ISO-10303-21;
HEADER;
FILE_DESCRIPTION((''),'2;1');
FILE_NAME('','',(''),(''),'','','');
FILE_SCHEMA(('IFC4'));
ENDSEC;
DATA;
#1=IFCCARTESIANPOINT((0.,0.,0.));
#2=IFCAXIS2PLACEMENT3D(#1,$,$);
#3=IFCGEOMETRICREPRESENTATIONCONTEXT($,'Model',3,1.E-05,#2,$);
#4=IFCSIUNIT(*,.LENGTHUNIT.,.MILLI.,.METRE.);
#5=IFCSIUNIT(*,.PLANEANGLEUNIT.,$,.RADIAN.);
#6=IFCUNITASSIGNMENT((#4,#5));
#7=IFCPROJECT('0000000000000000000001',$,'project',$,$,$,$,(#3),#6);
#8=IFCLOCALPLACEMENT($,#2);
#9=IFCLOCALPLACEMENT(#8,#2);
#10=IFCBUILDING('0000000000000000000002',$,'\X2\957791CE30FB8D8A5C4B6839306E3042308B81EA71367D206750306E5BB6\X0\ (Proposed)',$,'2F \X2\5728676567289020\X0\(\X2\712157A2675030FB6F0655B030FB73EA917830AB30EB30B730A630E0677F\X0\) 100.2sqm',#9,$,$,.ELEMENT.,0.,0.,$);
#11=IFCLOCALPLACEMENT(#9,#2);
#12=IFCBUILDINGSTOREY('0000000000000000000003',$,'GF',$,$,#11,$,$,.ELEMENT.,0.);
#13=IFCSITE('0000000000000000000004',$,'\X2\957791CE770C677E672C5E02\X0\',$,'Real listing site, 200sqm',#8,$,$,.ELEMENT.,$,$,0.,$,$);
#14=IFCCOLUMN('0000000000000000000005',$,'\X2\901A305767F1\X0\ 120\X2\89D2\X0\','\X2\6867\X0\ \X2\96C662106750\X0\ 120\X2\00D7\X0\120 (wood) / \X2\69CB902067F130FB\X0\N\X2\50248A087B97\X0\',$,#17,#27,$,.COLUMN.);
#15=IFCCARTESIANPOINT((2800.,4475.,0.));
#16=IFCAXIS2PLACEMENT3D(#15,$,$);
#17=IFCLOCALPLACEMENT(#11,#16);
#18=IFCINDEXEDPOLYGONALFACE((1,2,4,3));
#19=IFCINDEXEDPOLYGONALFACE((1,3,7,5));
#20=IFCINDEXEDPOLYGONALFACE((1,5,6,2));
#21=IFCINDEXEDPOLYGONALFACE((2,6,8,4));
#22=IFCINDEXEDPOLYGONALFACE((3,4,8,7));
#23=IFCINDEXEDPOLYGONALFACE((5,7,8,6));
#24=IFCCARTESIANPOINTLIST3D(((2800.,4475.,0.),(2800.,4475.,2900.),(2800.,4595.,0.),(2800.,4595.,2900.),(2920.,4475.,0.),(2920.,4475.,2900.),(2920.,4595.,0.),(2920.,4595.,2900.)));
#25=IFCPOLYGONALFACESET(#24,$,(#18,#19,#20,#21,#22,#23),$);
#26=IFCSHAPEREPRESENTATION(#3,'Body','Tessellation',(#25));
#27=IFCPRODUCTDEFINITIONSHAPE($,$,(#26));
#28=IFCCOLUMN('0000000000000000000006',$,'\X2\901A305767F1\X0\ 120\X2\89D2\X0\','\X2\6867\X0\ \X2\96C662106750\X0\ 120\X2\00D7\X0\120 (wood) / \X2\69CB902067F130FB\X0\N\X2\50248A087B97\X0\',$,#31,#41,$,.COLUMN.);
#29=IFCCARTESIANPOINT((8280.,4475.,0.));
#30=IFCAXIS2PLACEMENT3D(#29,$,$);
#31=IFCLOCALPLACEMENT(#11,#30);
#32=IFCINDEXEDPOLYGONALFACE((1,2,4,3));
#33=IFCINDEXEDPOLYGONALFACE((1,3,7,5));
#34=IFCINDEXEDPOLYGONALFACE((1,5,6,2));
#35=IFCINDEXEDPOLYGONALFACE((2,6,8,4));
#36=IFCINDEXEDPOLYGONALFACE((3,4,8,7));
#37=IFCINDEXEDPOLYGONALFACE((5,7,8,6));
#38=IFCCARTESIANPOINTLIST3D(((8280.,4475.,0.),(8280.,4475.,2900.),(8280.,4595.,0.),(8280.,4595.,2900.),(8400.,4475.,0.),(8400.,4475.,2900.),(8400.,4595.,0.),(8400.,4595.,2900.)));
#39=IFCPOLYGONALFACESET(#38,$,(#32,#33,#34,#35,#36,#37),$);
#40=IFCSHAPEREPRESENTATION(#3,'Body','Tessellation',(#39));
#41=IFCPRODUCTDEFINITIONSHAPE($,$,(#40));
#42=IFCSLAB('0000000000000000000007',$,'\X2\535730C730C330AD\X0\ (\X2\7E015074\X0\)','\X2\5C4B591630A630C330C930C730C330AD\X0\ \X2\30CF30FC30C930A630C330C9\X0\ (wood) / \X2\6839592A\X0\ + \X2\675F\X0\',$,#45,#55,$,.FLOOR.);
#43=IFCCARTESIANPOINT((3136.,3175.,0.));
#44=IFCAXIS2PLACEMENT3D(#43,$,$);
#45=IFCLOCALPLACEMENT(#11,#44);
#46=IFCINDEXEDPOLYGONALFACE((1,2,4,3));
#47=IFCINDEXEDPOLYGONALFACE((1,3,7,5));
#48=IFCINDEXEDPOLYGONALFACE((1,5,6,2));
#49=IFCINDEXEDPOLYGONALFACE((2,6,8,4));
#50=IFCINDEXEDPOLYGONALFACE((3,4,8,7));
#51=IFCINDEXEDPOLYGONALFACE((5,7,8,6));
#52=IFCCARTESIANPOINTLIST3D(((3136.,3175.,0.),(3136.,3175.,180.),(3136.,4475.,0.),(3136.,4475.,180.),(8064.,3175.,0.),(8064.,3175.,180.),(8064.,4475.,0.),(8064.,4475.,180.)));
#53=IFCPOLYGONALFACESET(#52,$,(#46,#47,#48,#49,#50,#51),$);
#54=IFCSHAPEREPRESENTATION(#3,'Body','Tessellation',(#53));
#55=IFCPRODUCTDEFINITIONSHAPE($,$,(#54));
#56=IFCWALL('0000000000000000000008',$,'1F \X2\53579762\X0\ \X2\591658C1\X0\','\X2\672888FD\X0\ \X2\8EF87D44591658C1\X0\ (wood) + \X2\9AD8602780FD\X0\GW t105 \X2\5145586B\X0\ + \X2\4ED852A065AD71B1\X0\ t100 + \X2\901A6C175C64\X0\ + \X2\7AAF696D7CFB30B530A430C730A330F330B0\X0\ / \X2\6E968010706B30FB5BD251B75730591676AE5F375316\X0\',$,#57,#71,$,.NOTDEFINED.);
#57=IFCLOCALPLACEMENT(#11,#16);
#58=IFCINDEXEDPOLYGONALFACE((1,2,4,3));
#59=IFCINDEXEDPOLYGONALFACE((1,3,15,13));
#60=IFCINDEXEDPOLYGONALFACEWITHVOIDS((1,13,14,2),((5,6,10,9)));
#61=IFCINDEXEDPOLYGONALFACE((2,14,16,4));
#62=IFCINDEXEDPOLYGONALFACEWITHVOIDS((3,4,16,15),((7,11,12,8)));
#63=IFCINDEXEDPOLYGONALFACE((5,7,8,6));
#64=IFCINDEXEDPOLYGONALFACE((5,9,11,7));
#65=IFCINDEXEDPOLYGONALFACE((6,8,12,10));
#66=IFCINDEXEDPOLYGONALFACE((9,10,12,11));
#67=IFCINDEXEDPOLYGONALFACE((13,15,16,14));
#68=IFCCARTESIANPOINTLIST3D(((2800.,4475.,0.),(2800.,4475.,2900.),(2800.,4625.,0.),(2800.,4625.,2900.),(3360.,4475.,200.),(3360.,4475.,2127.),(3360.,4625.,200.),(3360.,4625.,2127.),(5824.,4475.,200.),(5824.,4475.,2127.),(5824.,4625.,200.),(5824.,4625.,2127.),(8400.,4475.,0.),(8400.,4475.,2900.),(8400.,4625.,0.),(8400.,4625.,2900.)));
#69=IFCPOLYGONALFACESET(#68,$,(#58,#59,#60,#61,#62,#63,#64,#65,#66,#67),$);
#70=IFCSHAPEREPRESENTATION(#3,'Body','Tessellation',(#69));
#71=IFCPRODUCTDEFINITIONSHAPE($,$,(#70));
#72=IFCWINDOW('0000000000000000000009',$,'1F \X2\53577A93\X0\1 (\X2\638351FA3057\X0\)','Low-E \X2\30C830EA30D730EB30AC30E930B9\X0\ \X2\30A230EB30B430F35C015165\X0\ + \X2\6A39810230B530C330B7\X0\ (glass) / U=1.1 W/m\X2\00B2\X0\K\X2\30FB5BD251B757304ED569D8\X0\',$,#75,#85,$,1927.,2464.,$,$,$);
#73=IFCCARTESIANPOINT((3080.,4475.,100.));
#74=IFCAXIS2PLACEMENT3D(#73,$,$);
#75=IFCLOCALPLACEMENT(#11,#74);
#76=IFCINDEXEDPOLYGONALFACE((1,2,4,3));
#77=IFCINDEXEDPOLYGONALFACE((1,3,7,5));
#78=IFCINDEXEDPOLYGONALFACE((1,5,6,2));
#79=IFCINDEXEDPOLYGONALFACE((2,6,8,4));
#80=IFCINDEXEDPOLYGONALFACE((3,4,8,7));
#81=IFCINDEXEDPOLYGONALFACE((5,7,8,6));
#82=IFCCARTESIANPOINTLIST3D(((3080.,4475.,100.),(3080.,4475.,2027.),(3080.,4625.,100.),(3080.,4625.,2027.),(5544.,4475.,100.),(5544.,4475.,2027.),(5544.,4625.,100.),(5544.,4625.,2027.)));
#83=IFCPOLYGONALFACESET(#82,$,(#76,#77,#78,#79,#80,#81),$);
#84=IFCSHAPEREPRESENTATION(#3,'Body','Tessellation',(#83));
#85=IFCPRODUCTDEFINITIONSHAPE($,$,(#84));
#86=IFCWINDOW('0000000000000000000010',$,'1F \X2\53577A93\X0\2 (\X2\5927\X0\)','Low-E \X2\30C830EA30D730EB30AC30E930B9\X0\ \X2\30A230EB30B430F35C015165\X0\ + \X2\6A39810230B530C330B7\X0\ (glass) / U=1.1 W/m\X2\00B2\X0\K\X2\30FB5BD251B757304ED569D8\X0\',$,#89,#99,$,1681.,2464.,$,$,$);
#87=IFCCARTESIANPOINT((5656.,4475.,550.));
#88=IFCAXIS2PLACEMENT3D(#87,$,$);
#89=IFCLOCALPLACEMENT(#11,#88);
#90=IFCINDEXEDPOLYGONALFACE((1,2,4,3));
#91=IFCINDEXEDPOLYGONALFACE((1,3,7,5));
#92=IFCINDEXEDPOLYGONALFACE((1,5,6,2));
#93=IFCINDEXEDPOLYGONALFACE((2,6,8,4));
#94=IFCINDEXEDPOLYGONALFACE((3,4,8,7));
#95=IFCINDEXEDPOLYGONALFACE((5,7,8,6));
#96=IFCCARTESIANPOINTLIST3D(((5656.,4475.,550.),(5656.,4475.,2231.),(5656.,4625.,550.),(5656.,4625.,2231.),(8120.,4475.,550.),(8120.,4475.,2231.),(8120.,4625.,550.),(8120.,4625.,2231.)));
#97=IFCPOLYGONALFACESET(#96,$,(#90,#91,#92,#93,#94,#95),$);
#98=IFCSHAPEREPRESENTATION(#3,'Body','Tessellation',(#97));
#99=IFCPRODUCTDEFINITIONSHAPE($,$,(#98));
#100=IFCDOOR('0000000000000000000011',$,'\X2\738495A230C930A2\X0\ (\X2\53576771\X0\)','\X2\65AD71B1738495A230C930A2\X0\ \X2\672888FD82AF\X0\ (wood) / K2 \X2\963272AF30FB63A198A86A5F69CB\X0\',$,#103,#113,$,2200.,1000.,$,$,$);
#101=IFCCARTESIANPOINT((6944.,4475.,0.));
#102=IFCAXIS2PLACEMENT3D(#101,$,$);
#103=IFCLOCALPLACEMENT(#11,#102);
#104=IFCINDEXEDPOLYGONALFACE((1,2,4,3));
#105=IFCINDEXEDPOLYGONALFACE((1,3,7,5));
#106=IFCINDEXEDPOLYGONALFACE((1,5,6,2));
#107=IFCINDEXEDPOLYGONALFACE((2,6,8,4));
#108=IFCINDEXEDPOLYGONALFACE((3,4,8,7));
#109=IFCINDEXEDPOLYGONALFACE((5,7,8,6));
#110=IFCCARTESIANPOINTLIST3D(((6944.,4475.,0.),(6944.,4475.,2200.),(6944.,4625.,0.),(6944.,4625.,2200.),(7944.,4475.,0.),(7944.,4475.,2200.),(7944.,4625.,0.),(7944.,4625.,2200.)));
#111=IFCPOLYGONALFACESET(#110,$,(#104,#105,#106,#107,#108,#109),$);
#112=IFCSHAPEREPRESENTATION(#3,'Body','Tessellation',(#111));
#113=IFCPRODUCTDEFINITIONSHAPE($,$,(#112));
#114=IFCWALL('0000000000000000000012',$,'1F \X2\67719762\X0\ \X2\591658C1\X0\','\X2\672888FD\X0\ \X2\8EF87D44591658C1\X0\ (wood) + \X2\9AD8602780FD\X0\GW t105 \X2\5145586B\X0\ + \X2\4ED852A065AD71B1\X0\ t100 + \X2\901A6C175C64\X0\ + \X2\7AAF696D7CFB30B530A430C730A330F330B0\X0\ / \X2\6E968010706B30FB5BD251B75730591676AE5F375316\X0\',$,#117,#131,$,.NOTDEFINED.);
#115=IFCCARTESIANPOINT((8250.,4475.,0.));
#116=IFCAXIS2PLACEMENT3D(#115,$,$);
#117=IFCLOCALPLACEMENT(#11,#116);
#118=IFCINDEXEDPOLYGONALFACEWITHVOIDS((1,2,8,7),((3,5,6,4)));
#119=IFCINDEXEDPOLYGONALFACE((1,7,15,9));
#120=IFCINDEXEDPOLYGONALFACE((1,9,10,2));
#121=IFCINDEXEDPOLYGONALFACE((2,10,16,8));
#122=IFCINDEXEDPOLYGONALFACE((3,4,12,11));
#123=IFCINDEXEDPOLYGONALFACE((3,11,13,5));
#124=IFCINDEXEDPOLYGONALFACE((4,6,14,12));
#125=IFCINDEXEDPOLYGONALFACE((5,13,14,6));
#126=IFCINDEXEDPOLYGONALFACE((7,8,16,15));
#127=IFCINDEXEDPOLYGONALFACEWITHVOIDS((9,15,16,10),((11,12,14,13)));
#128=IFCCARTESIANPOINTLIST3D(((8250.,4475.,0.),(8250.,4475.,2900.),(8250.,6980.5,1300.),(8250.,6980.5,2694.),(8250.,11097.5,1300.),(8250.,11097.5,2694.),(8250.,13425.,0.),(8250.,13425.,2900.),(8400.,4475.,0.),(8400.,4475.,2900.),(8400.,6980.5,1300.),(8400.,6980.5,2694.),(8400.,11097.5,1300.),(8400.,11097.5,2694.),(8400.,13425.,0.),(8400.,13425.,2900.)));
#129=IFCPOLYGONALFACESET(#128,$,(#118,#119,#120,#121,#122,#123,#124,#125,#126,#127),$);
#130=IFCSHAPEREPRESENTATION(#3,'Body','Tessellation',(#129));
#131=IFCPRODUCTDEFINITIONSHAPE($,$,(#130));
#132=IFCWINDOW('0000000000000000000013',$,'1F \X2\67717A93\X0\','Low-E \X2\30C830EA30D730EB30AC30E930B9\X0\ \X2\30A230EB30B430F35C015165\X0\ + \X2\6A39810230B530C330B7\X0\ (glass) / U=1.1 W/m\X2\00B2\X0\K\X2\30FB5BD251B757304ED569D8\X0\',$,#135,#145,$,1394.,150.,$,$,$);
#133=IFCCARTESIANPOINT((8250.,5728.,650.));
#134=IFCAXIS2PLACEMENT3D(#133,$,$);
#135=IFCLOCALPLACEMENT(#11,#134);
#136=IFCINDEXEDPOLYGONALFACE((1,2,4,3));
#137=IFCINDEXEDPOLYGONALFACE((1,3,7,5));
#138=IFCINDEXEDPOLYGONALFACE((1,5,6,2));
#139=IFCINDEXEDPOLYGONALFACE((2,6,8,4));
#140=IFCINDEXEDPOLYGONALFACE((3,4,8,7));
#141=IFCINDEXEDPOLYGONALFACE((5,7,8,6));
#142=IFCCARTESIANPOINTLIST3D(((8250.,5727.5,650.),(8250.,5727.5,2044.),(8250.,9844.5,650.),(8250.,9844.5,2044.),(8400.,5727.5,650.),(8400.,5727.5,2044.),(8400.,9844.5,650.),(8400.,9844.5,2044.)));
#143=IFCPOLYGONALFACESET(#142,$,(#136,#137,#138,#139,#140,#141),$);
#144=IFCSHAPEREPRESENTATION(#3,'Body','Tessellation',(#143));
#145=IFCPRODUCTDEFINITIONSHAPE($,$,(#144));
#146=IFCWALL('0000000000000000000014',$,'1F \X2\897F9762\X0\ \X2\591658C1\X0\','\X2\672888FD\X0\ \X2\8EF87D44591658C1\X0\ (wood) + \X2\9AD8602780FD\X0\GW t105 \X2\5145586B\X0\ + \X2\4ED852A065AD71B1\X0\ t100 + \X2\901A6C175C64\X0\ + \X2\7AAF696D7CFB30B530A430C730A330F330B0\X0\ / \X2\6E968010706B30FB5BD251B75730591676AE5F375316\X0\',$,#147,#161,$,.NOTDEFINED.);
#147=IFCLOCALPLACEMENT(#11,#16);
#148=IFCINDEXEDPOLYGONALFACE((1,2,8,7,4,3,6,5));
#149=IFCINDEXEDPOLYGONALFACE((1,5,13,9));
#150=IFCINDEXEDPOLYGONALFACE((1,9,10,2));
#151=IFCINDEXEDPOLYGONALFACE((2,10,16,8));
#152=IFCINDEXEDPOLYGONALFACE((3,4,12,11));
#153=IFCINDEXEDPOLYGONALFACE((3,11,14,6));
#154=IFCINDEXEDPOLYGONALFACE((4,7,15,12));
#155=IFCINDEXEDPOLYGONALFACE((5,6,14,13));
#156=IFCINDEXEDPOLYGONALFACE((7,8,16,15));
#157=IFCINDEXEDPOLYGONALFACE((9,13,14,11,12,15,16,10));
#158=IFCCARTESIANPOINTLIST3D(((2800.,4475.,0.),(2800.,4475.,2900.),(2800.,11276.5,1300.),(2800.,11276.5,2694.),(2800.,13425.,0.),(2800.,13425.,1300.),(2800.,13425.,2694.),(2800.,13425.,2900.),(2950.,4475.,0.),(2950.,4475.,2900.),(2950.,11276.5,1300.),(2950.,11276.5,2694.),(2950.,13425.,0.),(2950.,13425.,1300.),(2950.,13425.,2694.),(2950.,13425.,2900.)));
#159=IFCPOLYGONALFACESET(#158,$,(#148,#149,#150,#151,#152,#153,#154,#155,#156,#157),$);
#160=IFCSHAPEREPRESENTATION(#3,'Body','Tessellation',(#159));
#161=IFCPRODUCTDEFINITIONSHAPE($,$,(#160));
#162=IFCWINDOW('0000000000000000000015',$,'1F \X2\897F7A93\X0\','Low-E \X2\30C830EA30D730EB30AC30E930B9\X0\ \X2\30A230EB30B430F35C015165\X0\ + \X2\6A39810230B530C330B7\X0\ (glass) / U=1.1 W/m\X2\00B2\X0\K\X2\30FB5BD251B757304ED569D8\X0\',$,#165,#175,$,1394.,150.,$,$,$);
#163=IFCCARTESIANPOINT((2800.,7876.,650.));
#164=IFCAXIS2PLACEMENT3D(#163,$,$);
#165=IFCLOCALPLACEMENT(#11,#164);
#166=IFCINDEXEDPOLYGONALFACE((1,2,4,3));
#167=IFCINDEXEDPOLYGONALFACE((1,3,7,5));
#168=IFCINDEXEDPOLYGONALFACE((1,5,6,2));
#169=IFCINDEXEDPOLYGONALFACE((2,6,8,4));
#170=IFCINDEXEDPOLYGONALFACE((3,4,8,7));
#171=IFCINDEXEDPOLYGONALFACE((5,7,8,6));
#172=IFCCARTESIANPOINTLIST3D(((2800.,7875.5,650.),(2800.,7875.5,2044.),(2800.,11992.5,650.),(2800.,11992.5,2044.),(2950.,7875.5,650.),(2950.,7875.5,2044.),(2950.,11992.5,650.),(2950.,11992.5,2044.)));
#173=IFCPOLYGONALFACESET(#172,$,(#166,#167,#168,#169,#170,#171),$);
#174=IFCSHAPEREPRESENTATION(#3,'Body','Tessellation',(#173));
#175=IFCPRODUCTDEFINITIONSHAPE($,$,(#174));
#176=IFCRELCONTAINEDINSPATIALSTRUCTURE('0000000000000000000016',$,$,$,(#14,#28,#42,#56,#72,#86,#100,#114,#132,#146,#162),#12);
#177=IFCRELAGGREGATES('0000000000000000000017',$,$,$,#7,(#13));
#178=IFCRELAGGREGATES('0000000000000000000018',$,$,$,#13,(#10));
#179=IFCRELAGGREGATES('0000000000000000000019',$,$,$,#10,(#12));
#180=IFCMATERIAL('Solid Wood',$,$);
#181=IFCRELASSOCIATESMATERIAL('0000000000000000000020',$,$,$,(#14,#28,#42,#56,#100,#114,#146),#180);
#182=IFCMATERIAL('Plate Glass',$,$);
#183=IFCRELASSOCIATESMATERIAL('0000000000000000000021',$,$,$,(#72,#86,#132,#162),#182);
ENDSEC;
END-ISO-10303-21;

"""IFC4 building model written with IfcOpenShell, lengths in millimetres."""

from ifc_helpers import new_model, si_unit, frame, frame_2d, origin, place, context, project, spatial, rectangle, extrude, material, element, fill, save


model = new_model("IFC4")

# Units and contexts
model_context = context("Model", 3, precision=1e-05, world=origin())
ifc_project = project(units=[si_unit("LENGTHUNIT", "METRE", prefix="MILLI"), si_unit("PLANEANGLEUNIT", "RADIAN")], contexts=[model_context])

# Site, building, storey
site_placement = place(None, origin())
site = spatial("IfcSite", under=ifc_project, at=site_placement, Name="長野県松本市", ObjectType="Real listing site, 200sqm", CompositionType="ELEMENT", RefElevation=0.0)
building_placement = place(site_placement, origin())
building = spatial("IfcBuilding", under=site, at=building_placement, Name="長野・越屋根のある自然素材の家 (Proposed)", ObjectType="2F 在来木造(無垢材・漆喰・珪酸カルシウム板) 100.2sqm", CompositionType="ELEMENT", ElevationOfRefHeight=0.0, ElevationOfTerrain=0.0)
storey_placement = place(building_placement, origin())
storey = spatial("IfcBuildingStorey", under=building, at=storey_placement, Name="GF", CompositionType="ELEMENT", Elevation=0.0)

# Columns
ifc_material_1 = material(Name="Solid Wood")
column_1_placement = place(storey_placement, frame((2800.0, 4475.0, 0.0)))
element("IfcColumn", 1, at=column_1_placement, inside=storey, material=ifc_material_1, Name="通し柱 120角", Description="桧 集成材 120×120 (wood) / 構造柱・N値計算", PredefinedType="COLUMN", context=model_context, shape_type="SweptSolid", body=[
    extrude(rectangle(XDim=120.0, YDim=120.0, at=frame_2d((60.0, 60.0))), frame((2800.0, 4475.0, 0.0)), (0.0, 0.0, 1.0), 2900.0),
])
column_2_placement = place(storey_placement, frame((8280.0, 4475.0, 0.0)))
element("IfcColumn", 2, at=column_2_placement, inside=storey, material=ifc_material_1, Name="通し柱 120角", Description="桧 集成材 120×120 (wood) / 構造柱・N値計算", PredefinedType="COLUMN", context=model_context, shape_type="SweptSolid", body=[
    extrude(rectangle(XDim=120.0, YDim=120.0, at=frame_2d((60.0, 60.0))), frame((8280.0, 4475.0, 0.0)), (0.0, 0.0, 1.0), 2900.0),
])

# Slab
slab_1_placement = place(storey_placement, frame((3136.0, 3175.0, 0.0)))
element("IfcSlab", 3, at=slab_1_placement, inside=storey, material=ifc_material_1, Name="南デッキ (縁側)", Description="屋外ウッドデッキ ハードウッド (wood) / 根太 + 束", PredefinedType="FLOOR", context=model_context, shape_type="SweptSolid", body=[
    extrude(rectangle(XDim=4928.0, YDim=1300.0, at=frame_2d((2464.0, 650.0))), frame((3136.0, 3175.0, 0.0)), (0.0, 0.0, 1.0), 180.0),
])

# Wall, openings, windows, door
wall_1_placement = place(storey_placement, frame((2800.0, 4475.0, 0.0)))
wall_1 = element("IfcWall", 4, at=wall_1_placement, inside=storey, material=ifc_material_1, Name="1F 南面 外壁", Description="木製 軸組外壁 (wood) + 高性能GW t105 充填 + 付加断熱 t100 + 通気層 + 窯業系サイディング / 準耐火・寒冷地外皮強化", PredefinedType="NOTDEFINED", context=model_context, shape_type="SweptSolid", body=[
    extrude(rectangle(XDim=5600.0, YDim=150.0, at=frame_2d((2800.0, 75.0))), frame((2800.0, 4475.0, 0.0)), (0.0, 0.0, 1.0), 2900.0),
])
opening_1_placement = place(storey_placement, frame((3080.0, 4475.0, 100.0)))
opening_1 = element("IfcOpeningElement", 5, at=opening_1_placement, cuts=wall_1, PredefinedType="NOTDEFINED", context=model_context, shape_type="SweptSolid", body=[
    extrude(rectangle(XDim=2464.0, YDim=150.0, at=frame_2d((1232.0, 75.0))), frame((3080.0, 4475.0, 100.0)), (0.0, 0.0, 1.0), 1927.0),
])
opening_2_placement = place(storey_placement, frame((5656.0, 4475.0, 550.0)))
opening_2 = element("IfcOpeningElement", 6, at=opening_2_placement, cuts=wall_1, PredefinedType="NOTDEFINED", context=model_context, shape_type="SweptSolid", body=[
    extrude(rectangle(XDim=2464.0, YDim=150.0, at=frame_2d((1232.0, 75.0))), frame((5656.0, 4475.0, 550.0)), (0.0, 0.0, 1.0), 1681.0),
])
opening_3_placement = place(storey_placement, frame((6944.0, 4475.0, 0.0)))
opening_3 = element("IfcOpeningElement", 7, at=opening_3_placement, cuts=wall_1, PredefinedType="NOTDEFINED", context=model_context, shape_type="SweptSolid", body=[
    extrude(rectangle(XDim=1000.0, YDim=150.0, at=frame_2d((500.0, 75.0))), frame((6944.0, 4475.0, 0.0)), (0.0, 0.0, 1.0), 2200.0),
])
ifc_material_2 = material(Name="Plate Glass")
window_1_placement = place(storey_placement, frame((3080.0, 4475.0, 100.0)))
window_1 = element("IfcWindow", 8, at=window_1_placement, inside=storey, material=ifc_material_2, Name="1F 南窓1 (掃出し)", Description="Low-E トリプルガラス アルゴン封入 + 樹脂サッシ (glass) / U=1.1 W/m²K・寒冷地仕様", OverallHeight=1927.0, OverallWidth=2464.0, context=model_context, shape_type="SweptSolid", body=[
    extrude(rectangle(XDim=2464.0, YDim=150.0, at=frame_2d((1232.0, 75.0))), frame((3080.0, 4475.0, 100.0)), (0.0, 0.0, 1.0), 1927.0),
])
fill(opening_1, window_1)
window_2_placement = place(storey_placement, frame((5656.0, 4475.0, 550.0)))
window_2 = element("IfcWindow", 9, at=window_2_placement, inside=storey, material=ifc_material_2, Name="1F 南窓2 (大)", Description="Low-E トリプルガラス アルゴン封入 + 樹脂サッシ (glass) / U=1.1 W/m²K・寒冷地仕様", OverallHeight=1681.0, OverallWidth=2464.0, context=model_context, shape_type="SweptSolid", body=[
    extrude(rectangle(XDim=2464.0, YDim=150.0, at=frame_2d((1232.0, 75.0))), frame((5656.0, 4475.0, 550.0)), (0.0, 0.0, 1.0), 1681.0),
])
fill(opening_2, window_2)
door_placement = place(storey_placement, frame((6944.0, 4475.0, 0.0)))
door = element("IfcDoor", 10, at=door_placement, inside=storey, material=ifc_material_1, Name="玄関ドア (南東)", Description="断熱玄関ドア 木製芯 (wood) / K2 防犯・採風機構", OverallHeight=2200.0, OverallWidth=1000.0, context=model_context, shape_type="SweptSolid", body=[
    extrude(rectangle(XDim=1000.0, YDim=150.0, at=frame_2d((500.0, 75.0))), frame((6944.0, 4475.0, 0.0)), (0.0, 0.0, 1.0), 2200.0),
])
fill(opening_3, door)

# Walls, openings, windows
wall_2_placement = place(storey_placement, frame((8250.0, 4475.0, 0.0)))
wall_2 = element("IfcWall", 11, at=wall_2_placement, inside=storey, material=ifc_material_1, Name="1F 東面 外壁", Description="木製 軸組外壁 (wood) + 高性能GW t105 充填 + 付加断熱 t100 + 通気層 + 窯業系サイディング / 準耐火・寒冷地外皮強化", PredefinedType="NOTDEFINED", context=model_context, shape_type="SweptSolid", body=[
    extrude(rectangle(XDim=150.0, YDim=8950.0, at=frame_2d((75.0, 4475.0))), frame((8250.0, 4475.0, 0.0)), (0.0, 0.0, 1.0), 2900.0),
])
opening_4_placement = place(storey_placement, frame((8250.0, 5728.0, 650.0)))
opening_4 = element("IfcOpeningElement", 12, at=opening_4_placement, cuts=wall_2, PredefinedType="NOTDEFINED", context=model_context, shape_type="SweptSolid", body=[
    extrude(rectangle(XDim=150.0, YDim=4117.0, at=frame_2d((75.0, 2058.0))), frame((8250.0, 5728.0, 650.0)), (0.0, 0.0, 1.0), 1394.0),
])
window_3_placement = place(storey_placement, frame((8250.0, 5728.0, 650.0)))
window_3 = element("IfcWindow", 13, at=window_3_placement, inside=storey, material=ifc_material_2, Name="1F 東窓", Description="Low-E トリプルガラス アルゴン封入 + 樹脂サッシ (glass) / U=1.1 W/m²K・寒冷地仕様", OverallHeight=1394.0, OverallWidth=150.0, context=model_context, shape_type="SweptSolid", body=[
    extrude(rectangle(XDim=150.0, YDim=4117.0, at=frame_2d((75.0, 2058.0))), frame((8250.0, 5728.0, 650.0)), (0.0, 0.0, 1.0), 1394.0),
])
fill(opening_4, window_3)
wall_3_placement = place(storey_placement, frame((2800.0, 4475.0, 0.0)))
wall_3 = element("IfcWall", 14, at=wall_3_placement, inside=storey, material=ifc_material_1, Name="1F 西面 外壁", Description="木製 軸組外壁 (wood) + 高性能GW t105 充填 + 付加断熱 t100 + 通気層 + 窯業系サイディング / 準耐火・寒冷地外皮強化", PredefinedType="NOTDEFINED", context=model_context, shape_type="SweptSolid", body=[
    extrude(rectangle(XDim=150.0, YDim=8950.0, at=frame_2d((75.0, 4475.0))), frame((2800.0, 4475.0, 0.0)), (0.0, 0.0, 1.0), 2900.0),
])
opening_5_placement = place(storey_placement, frame((2800.0, 7876.0, 650.0)))
opening_5 = element("IfcOpeningElement", 15, at=opening_5_placement, cuts=wall_3, PredefinedType="NOTDEFINED", context=model_context, shape_type="SweptSolid", body=[
    extrude(rectangle(XDim=150.0, YDim=4117.0, at=frame_2d((75.0, 2058.0))), frame((2800.0, 7876.0, 650.0)), (0.0, 0.0, 1.0), 1394.0),
])
window_4_placement = place(storey_placement, frame((2800.0, 7876.0, 650.0)))
window_4 = element("IfcWindow", 16, at=window_4_placement, inside=storey, material=ifc_material_2, Name="1F 西窓", Description="Low-E トリプルガラス アルゴン封入 + 樹脂サッシ (glass) / U=1.1 W/m²K・寒冷地仕様", OverallHeight=1394.0, OverallWidth=150.0, context=model_context, shape_type="SweptSolid", body=[
    extrude(rectangle(XDim=150.0, YDim=4117.0, at=frame_2d((75.0, 2058.0))), frame((2800.0, 7876.0, 650.0)), (0.0, 0.0, 1.0), 1394.0),
])
fill(opening_5, window_4)

save(model, "model.ifc")
